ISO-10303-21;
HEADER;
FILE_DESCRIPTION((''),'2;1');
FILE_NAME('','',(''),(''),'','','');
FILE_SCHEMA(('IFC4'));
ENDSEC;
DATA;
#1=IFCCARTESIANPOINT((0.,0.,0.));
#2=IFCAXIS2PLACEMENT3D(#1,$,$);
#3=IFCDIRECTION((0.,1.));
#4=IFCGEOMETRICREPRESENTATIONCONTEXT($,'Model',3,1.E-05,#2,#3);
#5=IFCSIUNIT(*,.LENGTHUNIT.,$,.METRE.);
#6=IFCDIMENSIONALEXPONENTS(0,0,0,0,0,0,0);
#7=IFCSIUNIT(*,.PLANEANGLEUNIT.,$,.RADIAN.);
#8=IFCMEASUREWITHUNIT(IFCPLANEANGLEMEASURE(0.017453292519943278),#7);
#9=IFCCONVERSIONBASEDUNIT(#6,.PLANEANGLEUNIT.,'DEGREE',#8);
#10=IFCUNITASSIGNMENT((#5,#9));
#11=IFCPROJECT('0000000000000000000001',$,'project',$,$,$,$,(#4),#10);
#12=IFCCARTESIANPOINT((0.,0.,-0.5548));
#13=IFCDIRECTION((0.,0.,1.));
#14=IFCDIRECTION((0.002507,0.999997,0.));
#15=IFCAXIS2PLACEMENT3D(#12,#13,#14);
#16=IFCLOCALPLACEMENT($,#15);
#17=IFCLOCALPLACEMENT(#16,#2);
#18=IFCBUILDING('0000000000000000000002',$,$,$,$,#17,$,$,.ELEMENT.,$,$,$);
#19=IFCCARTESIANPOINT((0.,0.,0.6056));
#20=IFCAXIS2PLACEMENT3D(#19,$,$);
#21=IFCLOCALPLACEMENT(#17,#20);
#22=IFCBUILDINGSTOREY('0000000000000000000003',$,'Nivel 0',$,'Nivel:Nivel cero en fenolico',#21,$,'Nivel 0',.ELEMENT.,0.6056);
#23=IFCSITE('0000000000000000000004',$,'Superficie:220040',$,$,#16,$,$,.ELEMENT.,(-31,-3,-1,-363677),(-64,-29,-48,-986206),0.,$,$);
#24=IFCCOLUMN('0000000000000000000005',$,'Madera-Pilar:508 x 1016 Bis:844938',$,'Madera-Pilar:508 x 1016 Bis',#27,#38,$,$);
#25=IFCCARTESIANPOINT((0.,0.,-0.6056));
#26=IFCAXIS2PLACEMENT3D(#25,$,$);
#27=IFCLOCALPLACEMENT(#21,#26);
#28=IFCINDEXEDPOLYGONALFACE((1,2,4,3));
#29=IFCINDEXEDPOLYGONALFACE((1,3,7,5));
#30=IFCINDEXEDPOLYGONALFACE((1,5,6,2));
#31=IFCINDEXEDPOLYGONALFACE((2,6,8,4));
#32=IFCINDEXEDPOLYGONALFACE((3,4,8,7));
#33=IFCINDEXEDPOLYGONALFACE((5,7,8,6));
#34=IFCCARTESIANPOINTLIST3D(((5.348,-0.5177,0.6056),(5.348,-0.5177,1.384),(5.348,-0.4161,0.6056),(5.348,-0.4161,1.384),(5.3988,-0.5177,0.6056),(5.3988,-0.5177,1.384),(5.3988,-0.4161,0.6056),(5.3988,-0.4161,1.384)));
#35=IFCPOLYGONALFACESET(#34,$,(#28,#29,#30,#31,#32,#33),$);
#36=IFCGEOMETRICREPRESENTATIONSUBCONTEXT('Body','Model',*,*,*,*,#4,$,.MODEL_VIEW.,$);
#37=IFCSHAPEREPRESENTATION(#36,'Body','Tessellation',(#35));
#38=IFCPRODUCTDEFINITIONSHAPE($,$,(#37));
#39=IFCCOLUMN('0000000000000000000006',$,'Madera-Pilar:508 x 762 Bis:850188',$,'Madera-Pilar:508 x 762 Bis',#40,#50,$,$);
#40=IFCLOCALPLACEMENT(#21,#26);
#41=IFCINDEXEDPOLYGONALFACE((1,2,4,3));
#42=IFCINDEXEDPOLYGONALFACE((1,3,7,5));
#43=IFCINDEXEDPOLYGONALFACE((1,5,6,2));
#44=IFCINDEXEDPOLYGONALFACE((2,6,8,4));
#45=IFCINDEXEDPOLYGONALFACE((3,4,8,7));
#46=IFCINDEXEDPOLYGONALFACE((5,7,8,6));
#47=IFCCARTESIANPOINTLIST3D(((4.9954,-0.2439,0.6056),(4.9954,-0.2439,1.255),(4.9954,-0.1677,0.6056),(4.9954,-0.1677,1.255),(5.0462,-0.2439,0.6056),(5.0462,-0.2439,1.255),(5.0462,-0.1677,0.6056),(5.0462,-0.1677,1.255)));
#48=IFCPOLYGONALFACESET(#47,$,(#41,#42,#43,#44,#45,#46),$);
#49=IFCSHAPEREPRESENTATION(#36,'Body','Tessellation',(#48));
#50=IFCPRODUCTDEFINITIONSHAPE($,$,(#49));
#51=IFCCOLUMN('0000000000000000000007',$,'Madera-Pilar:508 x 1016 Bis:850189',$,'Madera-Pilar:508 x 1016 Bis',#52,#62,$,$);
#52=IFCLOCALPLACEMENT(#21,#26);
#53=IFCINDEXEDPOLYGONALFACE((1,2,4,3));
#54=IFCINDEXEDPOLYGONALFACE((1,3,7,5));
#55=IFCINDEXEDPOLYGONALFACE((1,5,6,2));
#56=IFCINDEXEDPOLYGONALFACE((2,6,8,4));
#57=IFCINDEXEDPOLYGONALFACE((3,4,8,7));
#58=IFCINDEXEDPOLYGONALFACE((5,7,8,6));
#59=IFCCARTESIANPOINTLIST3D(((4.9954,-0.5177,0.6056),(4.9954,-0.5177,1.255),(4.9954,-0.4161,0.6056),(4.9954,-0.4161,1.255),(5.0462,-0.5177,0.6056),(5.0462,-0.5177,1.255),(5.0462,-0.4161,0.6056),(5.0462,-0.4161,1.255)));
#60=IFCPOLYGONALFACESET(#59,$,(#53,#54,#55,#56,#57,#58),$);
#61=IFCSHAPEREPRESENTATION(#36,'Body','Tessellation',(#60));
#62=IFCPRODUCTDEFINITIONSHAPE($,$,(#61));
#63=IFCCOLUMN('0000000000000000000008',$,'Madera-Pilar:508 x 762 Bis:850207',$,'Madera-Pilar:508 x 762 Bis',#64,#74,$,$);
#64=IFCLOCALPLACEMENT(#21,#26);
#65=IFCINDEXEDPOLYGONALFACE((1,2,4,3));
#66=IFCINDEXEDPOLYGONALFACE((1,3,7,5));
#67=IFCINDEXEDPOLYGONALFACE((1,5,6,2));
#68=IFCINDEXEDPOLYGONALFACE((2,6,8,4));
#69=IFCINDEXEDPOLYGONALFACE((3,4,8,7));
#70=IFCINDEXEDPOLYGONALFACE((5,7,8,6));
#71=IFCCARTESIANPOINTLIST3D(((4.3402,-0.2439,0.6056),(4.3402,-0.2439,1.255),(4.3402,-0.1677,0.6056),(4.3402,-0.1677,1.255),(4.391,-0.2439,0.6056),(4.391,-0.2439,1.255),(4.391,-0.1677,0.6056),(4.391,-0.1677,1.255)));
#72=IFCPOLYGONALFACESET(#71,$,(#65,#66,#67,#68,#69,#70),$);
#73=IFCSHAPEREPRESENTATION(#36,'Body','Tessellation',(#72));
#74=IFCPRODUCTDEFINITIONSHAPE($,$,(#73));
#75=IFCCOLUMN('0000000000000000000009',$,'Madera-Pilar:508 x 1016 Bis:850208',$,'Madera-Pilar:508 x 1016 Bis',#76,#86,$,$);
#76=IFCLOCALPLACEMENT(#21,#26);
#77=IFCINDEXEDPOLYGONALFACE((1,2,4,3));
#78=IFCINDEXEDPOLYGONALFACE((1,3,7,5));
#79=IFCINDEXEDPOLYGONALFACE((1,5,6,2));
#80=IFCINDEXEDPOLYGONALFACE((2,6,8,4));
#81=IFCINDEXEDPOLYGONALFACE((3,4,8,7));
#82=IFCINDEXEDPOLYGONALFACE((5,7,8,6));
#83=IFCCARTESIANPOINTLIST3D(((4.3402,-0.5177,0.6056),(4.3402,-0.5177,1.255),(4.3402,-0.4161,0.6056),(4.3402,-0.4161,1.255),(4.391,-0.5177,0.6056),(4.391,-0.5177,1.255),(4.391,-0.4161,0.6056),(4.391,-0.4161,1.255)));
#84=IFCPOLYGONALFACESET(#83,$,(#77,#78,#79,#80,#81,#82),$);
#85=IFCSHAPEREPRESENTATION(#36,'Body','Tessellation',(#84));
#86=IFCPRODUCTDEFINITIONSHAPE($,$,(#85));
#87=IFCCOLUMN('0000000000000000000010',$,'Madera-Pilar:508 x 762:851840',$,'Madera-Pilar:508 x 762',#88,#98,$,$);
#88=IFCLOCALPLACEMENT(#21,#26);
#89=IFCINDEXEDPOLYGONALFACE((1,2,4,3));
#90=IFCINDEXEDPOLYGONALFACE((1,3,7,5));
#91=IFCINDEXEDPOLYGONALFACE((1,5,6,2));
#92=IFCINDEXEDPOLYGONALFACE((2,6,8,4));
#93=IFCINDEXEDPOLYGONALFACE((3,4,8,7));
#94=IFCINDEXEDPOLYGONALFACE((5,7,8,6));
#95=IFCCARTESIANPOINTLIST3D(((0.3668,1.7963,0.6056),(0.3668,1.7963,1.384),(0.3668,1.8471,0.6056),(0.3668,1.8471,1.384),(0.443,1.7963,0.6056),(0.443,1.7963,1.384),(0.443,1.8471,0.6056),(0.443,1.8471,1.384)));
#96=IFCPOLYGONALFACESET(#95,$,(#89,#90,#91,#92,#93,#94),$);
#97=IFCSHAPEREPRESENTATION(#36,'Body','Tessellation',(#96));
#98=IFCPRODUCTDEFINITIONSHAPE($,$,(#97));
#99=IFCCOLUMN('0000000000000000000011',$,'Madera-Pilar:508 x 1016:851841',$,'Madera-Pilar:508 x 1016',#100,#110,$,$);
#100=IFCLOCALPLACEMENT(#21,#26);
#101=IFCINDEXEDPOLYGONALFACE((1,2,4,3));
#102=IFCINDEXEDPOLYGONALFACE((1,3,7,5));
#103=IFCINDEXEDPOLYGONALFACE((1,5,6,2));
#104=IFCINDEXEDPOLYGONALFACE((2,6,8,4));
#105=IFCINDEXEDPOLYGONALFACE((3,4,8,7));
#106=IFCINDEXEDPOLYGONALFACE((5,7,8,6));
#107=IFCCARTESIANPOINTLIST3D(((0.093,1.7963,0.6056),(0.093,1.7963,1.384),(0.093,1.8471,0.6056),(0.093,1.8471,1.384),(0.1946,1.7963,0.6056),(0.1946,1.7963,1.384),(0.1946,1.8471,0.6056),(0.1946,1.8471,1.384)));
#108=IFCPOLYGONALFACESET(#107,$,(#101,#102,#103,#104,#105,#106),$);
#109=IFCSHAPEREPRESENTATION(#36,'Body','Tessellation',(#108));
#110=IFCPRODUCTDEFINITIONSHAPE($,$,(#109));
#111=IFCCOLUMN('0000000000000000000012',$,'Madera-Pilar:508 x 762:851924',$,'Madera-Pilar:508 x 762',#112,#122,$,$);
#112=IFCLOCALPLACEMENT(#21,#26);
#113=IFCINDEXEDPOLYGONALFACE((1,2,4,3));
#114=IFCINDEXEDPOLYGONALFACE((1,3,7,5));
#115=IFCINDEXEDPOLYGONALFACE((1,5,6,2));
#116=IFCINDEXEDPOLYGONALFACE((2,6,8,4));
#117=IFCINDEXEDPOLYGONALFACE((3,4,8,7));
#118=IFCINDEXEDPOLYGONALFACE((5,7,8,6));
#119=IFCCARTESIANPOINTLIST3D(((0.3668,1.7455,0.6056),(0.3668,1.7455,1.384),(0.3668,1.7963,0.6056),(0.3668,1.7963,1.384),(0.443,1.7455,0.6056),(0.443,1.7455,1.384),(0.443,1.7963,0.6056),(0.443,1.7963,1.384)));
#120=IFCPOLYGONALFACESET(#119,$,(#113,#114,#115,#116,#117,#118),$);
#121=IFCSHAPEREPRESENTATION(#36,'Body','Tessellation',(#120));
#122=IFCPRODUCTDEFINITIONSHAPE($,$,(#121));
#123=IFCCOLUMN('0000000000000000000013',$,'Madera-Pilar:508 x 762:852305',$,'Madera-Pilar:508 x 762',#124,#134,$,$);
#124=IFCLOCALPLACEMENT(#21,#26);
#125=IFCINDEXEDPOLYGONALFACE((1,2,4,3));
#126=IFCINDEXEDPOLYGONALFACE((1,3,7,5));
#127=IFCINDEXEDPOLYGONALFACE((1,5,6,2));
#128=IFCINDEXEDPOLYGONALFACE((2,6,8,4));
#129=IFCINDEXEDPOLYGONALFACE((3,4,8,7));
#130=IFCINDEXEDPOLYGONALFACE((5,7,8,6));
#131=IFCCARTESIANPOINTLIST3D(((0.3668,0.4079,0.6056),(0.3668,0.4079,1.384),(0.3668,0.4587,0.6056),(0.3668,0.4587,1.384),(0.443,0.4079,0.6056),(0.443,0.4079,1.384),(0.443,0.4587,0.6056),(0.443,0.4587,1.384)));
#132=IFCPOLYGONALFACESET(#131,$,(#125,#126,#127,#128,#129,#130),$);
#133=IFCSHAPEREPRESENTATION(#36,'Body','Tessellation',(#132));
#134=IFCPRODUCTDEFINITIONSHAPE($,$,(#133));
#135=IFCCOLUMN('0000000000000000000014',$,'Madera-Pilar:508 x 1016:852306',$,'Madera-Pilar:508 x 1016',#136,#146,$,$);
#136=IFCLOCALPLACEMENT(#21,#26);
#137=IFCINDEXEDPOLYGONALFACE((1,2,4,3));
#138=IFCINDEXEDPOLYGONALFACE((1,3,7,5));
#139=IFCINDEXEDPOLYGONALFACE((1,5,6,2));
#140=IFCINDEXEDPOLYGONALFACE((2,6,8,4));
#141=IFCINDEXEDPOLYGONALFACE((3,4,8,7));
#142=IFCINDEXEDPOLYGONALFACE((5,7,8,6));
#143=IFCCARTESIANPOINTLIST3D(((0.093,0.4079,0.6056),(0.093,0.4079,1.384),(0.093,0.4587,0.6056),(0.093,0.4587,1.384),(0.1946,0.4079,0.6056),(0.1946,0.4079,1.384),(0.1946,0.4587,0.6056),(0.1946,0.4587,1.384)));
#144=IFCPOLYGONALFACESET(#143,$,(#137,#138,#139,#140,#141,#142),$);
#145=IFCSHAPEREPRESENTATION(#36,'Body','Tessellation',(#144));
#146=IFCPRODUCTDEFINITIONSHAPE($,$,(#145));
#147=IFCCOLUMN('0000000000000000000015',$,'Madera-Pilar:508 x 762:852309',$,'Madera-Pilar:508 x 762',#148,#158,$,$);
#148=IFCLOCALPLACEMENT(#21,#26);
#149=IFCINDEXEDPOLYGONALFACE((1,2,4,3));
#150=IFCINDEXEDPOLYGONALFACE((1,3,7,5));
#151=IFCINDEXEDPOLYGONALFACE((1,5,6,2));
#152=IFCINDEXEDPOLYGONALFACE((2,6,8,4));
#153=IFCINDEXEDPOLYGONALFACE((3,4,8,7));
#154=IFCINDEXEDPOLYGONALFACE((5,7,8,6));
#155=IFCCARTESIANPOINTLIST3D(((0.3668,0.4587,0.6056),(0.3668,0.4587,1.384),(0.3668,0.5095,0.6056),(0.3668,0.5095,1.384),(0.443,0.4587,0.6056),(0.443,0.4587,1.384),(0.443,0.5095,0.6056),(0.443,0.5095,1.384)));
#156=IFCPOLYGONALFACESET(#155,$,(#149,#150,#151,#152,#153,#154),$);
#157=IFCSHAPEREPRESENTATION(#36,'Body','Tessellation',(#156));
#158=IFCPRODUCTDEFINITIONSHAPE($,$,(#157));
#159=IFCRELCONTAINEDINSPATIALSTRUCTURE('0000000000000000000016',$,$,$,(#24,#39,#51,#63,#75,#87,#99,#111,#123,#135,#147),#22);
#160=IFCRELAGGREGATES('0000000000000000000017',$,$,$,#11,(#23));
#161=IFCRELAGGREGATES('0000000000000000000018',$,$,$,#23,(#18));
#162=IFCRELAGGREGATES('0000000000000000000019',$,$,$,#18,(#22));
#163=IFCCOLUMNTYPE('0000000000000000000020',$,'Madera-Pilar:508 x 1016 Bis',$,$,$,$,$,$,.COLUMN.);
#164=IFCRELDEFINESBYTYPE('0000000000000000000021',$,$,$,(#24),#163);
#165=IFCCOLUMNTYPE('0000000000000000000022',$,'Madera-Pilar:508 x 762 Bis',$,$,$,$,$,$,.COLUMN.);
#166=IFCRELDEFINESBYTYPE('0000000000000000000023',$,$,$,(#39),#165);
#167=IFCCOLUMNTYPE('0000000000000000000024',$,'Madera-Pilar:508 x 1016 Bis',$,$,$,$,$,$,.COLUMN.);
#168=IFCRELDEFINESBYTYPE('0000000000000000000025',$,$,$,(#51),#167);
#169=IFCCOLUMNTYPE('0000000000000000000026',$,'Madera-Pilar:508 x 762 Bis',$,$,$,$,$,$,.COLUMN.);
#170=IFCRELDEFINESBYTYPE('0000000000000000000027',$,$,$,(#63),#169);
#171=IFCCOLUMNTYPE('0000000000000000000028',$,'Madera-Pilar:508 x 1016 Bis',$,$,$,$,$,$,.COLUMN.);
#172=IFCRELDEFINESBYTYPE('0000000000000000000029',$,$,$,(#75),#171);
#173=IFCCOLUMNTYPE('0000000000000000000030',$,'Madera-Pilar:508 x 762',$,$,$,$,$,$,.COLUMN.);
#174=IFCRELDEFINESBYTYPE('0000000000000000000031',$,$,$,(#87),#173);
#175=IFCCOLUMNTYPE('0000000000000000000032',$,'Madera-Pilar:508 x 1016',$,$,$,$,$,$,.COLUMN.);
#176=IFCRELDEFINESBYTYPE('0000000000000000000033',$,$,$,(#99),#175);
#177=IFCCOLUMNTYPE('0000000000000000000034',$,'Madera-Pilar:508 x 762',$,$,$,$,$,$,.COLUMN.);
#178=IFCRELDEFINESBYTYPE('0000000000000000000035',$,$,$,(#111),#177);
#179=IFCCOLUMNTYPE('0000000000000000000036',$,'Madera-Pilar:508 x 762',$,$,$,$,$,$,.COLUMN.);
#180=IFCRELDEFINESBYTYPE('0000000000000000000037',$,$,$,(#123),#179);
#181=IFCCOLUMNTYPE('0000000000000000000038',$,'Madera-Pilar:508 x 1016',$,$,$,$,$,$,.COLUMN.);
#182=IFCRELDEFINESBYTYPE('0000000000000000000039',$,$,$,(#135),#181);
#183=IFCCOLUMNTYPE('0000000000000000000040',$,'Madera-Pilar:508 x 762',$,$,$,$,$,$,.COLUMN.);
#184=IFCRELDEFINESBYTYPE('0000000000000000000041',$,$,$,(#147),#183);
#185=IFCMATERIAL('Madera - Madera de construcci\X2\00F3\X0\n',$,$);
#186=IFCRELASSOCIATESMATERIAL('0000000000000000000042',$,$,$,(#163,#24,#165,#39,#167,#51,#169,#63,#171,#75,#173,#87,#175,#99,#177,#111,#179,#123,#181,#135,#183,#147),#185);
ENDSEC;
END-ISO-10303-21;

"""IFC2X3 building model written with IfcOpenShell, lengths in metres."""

from ifc_helpers import new_model, entity, si_unit, converted_unit, direction, frame, frame_2d, origin, place, context, subcontext, project, spatial, rectangle, extrude, source, transform, mapped, material, type_object, type_shapes, element, save


model = new_model("IFC2X3")

# Units and contexts
model_context = context("Model", 3, precision=1e-05, world=origin(), true_north=direction((0.0, 1.0)))
body_context = subcontext(model_context, "Body", "Model", "MODEL_VIEW")
ifc_project = project(units=[si_unit("LENGTHUNIT", "METRE"), converted_unit("PLANEANGLEUNIT", "DEGREE", entity("IfcPlaneAngleMeasure", 0.017453292519943278), si_unit("PLANEANGLEUNIT", "RADIAN"), dimensions=[0, 0, 0, 0, 0, 0, 0])], contexts=[model_context])

# Site, building, storey
site_placement = place(None, frame((0.0, 0.0, -0.5548), z_axis=(0.0, 0.0, 1.0), x_axis=(0.002507, 0.999997, 0.0)))
site = spatial("IfcSite", under=ifc_project, at=site_placement, Name="Superficie:220040", CompositionType="ELEMENT", RefLatitude=(-31, -3, -1, -363677), RefLongitude=(-64, -29, -48, -986206), RefElevation=0.0)
building_placement = place(site_placement, origin())
building = spatial("IfcBuilding", under=site, at=building_placement, CompositionType="ELEMENT")
storey_placement = place(building_placement, frame((0.0, 0.0, 0.6056)))
storey = spatial("IfcBuildingStorey", under=building, at=storey_placement, Name="Nivel 0", ObjectType="Nivel:Nivel cero en fenolico", LongName="Nivel 0", CompositionType="ELEMENT", Elevation=0.6056)

# Columns
ifc_material = material(Name="Madera - Madera de construcción")
column_type_1 = type_object("IfcColumnType", Name="Madera-Pilar:508 x 1016 Bis", PredefinedType="COLUMN", material=ifc_material)
shared_shape_1 = source(origin(), body_context, "Body", "SweptSolid", [
    extrude(rectangle(XDim=0.0508, YDim=0.1016, at=frame_2d((0.0, 0.0), x_axis=(1.0, 0.0))), frame((5.3734, -0.4669, 0.6056)), (0.0, 0.0, 1.0), 0.7784),
])
type_shapes(column_type_1, [shared_shape_1])
column_1_placement = place(storey_placement, frame((0.0, 0.0, -0.6056)))
element("IfcColumn", 1, at=column_1_placement, inside=storey, type_object=column_type_1, material=ifc_material, Name="Madera-Pilar:508 x 1016 Bis:844938", ObjectType="Madera-Pilar:508 x 1016 Bis", context=body_context, shape_type="MappedRepresentation", body=[
    mapped(shared_shape_1, transform((0.0, 0.0, 0.0), scale=1.0)),
])
column_type_2 = type_object("IfcColumnType", Name="Madera-Pilar:508 x 762 Bis", PredefinedType="COLUMN", material=ifc_material)
shared_shape_2 = source(origin(), body_context, "Body", "SweptSolid", [
    extrude(rectangle(XDim=0.0508, YDim=0.0762, at=frame_2d((0.0, 0.0), x_axis=(1.0, 0.0))), frame((5.0208, -0.2058, 0.6056), z_axis=(0.0, 0.0, 1.0), x_axis=(-1.0, 0.0, 0.0)), (0.0, 0.0, 1.0), 0.6494),
])
type_shapes(column_type_2, [shared_shape_2])
column_2_placement = place(storey_placement, frame((0.0, 0.0, -0.6056)))
element("IfcColumn", 2, at=column_2_placement, inside=storey, type_object=column_type_2, material=ifc_material, Name="Madera-Pilar:508 x 762 Bis:850188", ObjectType="Madera-Pilar:508 x 762 Bis", context=body_context, shape_type="MappedRepresentation", body=[
    mapped(shared_shape_2, transform((0.0, 0.0, 0.0), scale=1.0)),
])
column_type_3 = type_object("IfcColumnType", Name="Madera-Pilar:508 x 1016 Bis", PredefinedType="COLUMN", material=ifc_material)
shared_shape_3 = source(origin(), body_context, "Body", "SweptSolid", [
    extrude(rectangle(XDim=0.0508, YDim=0.1016, at=frame_2d((0.0, 0.0), x_axis=(1.0, 0.0))), frame((5.0208, -0.4669, 0.6056)), (0.0, 0.0, 1.0), 0.6494),
])
type_shapes(column_type_3, [shared_shape_3])
column_3_placement = place(storey_placement, frame((0.0, 0.0, -0.6056)))
element("IfcColumn", 3, at=column_3_placement, inside=storey, type_object=column_type_3, material=ifc_material, Name="Madera-Pilar:508 x 1016 Bis:850189", ObjectType="Madera-Pilar:508 x 1016 Bis", context=body_context, shape_type="MappedRepresentation", body=[
    mapped(shared_shape_3, transform((0.0, 0.0, 0.0), scale=1.0)),
])
column_type_4 = type_object("IfcColumnType", Name="Madera-Pilar:508 x 762 Bis", PredefinedType="COLUMN", material=ifc_material)
shared_shape_4 = source(origin(), body_context, "Body", "SweptSolid", [
    extrude(rectangle(XDim=0.0508, YDim=0.0762, at=frame_2d((0.0, 0.0), x_axis=(1.0, 0.0))), frame((4.3656, -0.2058, 0.6056), z_axis=(0.0, 0.0, 1.0), x_axis=(-1.0, 0.0, 0.0)), (0.0, 0.0, 1.0), 0.6494),
])
type_shapes(column_type_4, [shared_shape_4])
column_4_placement = place(storey_placement, frame((0.0, 0.0, -0.6056)))
element("IfcColumn", 4, at=column_4_placement, inside=storey, type_object=column_type_4, material=ifc_material, Name="Madera-Pilar:508 x 762 Bis:850207", ObjectType="Madera-Pilar:508 x 762 Bis", context=body_context, shape_type="MappedRepresentation", body=[
    mapped(shared_shape_4, transform((0.0, 0.0, 0.0), scale=1.0)),
])
column_type_5 = type_object("IfcColumnType", Name="Madera-Pilar:508 x 1016 Bis", PredefinedType="COLUMN", material=ifc_material)
shared_shape_5 = source(origin(), body_context, "Body", "SweptSolid", [
    extrude(rectangle(XDim=0.0508, YDim=0.1016, at=frame_2d((0.0, 0.0), x_axis=(1.0, 0.0))), frame((4.3656, -0.4669, 0.6056)), (0.0, 0.0, 1.0), 0.6494),
])
type_shapes(column_type_5, [shared_shape_5])
column_5_placement = place(storey_placement, frame((0.0, 0.0, -0.6056)))
element("IfcColumn", 5, at=column_5_placement, inside=storey, type_object=column_type_5, material=ifc_material, Name="Madera-Pilar:508 x 1016 Bis:850208", ObjectType="Madera-Pilar:508 x 1016 Bis", context=body_context, shape_type="MappedRepresentation", body=[
    mapped(shared_shape_5, transform((0.0, 0.0, 0.0), scale=1.0)),
])
column_type_6 = type_object("IfcColumnType", Name="Madera-Pilar:508 x 762", PredefinedType="COLUMN", material=ifc_material)
shared_shape_6 = source(origin(), body_context, "Body", "SweptSolid", [
    extrude(rectangle(XDim=0.0762, YDim=0.0508, at=frame_2d((0.0, 0.0), x_axis=(1.0, 0.0))), frame((0.4049, 1.8217, 0.6056), z_axis=(0.0, 0.0, 1.0), x_axis=(-1.0, 0.0, 0.0)), (0.0, 0.0, 1.0), 0.7784),
])
type_shapes(column_type_6, [shared_shape_6])
column_6_placement = place(storey_placement, frame((0.0, 0.0, -0.6056)))
element("IfcColumn", 6, at=column_6_placement, inside=storey, type_object=column_type_6, material=ifc_material, Name="Madera-Pilar:508 x 762:851840", ObjectType="Madera-Pilar:508 x 762", context=body_context, shape_type="MappedRepresentation", body=[
    mapped(shared_shape_6, transform((0.0, 0.0, 0.0), scale=1.0)),
])
column_type_7 = type_object("IfcColumnType", Name="Madera-Pilar:508 x 1016", PredefinedType="COLUMN", material=ifc_material)
shared_shape_7 = source(origin(), body_context, "Body", "SweptSolid", [
    extrude(rectangle(XDim=0.1016, YDim=0.0508, at=frame_2d((0.0, 0.0), x_axis=(1.0, 0.0))), frame((0.1438, 1.8217, 0.6056), z_axis=(0.0, 0.0, 1.0), x_axis=(-1.0, 0.0, 0.0)), (0.0, 0.0, 1.0), 0.7784),
])
type_shapes(column_type_7, [shared_shape_7])
column_7_placement = place(storey_placement, frame((0.0, 0.0, -0.6056)))
element("IfcColumn", 7, at=column_7_placement, inside=storey, type_object=column_type_7, material=ifc_material, Name="Madera-Pilar:508 x 1016:851841", ObjectType="Madera-Pilar:508 x 1016", context=body_context, shape_type="MappedRepresentation", body=[
    mapped(shared_shape_7, transform((0.0, 0.0, 0.0), scale=1.0)),
])
column_type_8 = type_object("IfcColumnType", Name="Madera-Pilar:508 x 762", PredefinedType="COLUMN", material=ifc_material)
shared_shape_8 = source(origin(), body_context, "Body", "SweptSolid", [
    extrude(rectangle(XDim=0.0762, YDim=0.0508, at=frame_2d((0.0, 0.0), x_axis=(1.0, 0.0))), frame((0.4049, 1.7709, 0.6056), z_axis=(0.0, 0.0, 1.0), x_axis=(-1.0, 0.0, 0.0)), (0.0, 0.0, 1.0), 0.7784),
])
type_shapes(column_type_8, [shared_shape_8])
column_8_placement = place(storey_placement, frame((0.0, 0.0, -0.6056)))
element("IfcColumn", 8, at=column_8_placement, inside=storey, type_object=column_type_8, material=ifc_material, Name="Madera-Pilar:508 x 762:851924", ObjectType="Madera-Pilar:508 x 762", context=body_context, shape_type="MappedRepresentation", body=[
    mapped(shared_shape_8, transform((0.0, 0.0, 0.0), scale=1.0)),
])
column_type_9 = type_object("IfcColumnType", Name="Madera-Pilar:508 x 762", PredefinedType="COLUMN", material=ifc_material)
shared_shape_9 = source(origin(), body_context, "Body", "SweptSolid", [
    extrude(rectangle(XDim=0.0762, YDim=0.0508, at=frame_2d((0.0, 0.0), x_axis=(1.0, 0.0))), frame((0.4049, 0.4333, 0.6056), z_axis=(0.0, 0.0, 1.0), x_axis=(-1.0, 0.0, 0.0)), (0.0, 0.0, 1.0), 0.7784),
])
type_shapes(column_type_9, [shared_shape_9])
column_9_placement = place(storey_placement, frame((0.0, 0.0, -0.6056)))
element("IfcColumn", 9, at=column_9_placement, inside=storey, type_object=column_type_9, material=ifc_material, Name="Madera-Pilar:508 x 762:852305", ObjectType="Madera-Pilar:508 x 762", context=body_context, shape_type="MappedRepresentation", body=[
    mapped(shared_shape_9, transform((0.0, 0.0, 0.0), scale=1.0)),
])
column_type_10 = type_object("IfcColumnType", Name="Madera-Pilar:508 x 1016", PredefinedType="COLUMN", material=ifc_material)
shared_shape_10 = source(origin(), body_context, "Body", "SweptSolid", [
    extrude(rectangle(XDim=0.1016, YDim=0.0508, at=frame_2d((0.0, 0.0), x_axis=(1.0, 0.0))), frame((0.1438, 0.4333, 0.6056), z_axis=(0.0, 0.0, 1.0), x_axis=(-1.0, 0.0, 0.0)), (0.0, 0.0, 1.0), 0.7784),
])
type_shapes(column_type_10, [shared_shape_10])
column_10_placement = place(storey_placement, frame((0.0, 0.0, -0.6056)))
element("IfcColumn", 10, at=column_10_placement, inside=storey, type_object=column_type_10, material=ifc_material, Name="Madera-Pilar:508 x 1016:852306", ObjectType="Madera-Pilar:508 x 1016", context=body_context, shape_type="MappedRepresentation", body=[
    mapped(shared_shape_10, transform((0.0, 0.0, 0.0), scale=1.0)),
])
column_type_11 = type_object("IfcColumnType", Name="Madera-Pilar:508 x 762", PredefinedType="COLUMN", material=ifc_material)
shared_shape_11 = source(origin(), body_context, "Body", "SweptSolid", [
    extrude(rectangle(XDim=0.0762, YDim=0.0508, at=frame_2d((0.0, 0.0), x_axis=(1.0, 0.0))), frame((0.4049, 0.4841, 0.6056), z_axis=(0.0, 0.0, 1.0), x_axis=(-1.0, 0.0, 0.0)), (0.0, 0.0, 1.0), 0.7784),
])
type_shapes(column_type_11, [shared_shape_11])
column_11_placement = place(storey_placement, frame((0.0, 0.0, -0.6056)))
element("IfcColumn", 11, at=column_11_placement, inside=storey, type_object=column_type_11, material=ifc_material, Name="Madera-Pilar:508 x 762:852309", ObjectType="Madera-Pilar:508 x 762", context=body_context, shape_type="MappedRepresentation", body=[
    mapped(shared_shape_11, transform((0.0, 0.0, 0.0), scale=1.0)),
])

save(model, "model.ifc")
